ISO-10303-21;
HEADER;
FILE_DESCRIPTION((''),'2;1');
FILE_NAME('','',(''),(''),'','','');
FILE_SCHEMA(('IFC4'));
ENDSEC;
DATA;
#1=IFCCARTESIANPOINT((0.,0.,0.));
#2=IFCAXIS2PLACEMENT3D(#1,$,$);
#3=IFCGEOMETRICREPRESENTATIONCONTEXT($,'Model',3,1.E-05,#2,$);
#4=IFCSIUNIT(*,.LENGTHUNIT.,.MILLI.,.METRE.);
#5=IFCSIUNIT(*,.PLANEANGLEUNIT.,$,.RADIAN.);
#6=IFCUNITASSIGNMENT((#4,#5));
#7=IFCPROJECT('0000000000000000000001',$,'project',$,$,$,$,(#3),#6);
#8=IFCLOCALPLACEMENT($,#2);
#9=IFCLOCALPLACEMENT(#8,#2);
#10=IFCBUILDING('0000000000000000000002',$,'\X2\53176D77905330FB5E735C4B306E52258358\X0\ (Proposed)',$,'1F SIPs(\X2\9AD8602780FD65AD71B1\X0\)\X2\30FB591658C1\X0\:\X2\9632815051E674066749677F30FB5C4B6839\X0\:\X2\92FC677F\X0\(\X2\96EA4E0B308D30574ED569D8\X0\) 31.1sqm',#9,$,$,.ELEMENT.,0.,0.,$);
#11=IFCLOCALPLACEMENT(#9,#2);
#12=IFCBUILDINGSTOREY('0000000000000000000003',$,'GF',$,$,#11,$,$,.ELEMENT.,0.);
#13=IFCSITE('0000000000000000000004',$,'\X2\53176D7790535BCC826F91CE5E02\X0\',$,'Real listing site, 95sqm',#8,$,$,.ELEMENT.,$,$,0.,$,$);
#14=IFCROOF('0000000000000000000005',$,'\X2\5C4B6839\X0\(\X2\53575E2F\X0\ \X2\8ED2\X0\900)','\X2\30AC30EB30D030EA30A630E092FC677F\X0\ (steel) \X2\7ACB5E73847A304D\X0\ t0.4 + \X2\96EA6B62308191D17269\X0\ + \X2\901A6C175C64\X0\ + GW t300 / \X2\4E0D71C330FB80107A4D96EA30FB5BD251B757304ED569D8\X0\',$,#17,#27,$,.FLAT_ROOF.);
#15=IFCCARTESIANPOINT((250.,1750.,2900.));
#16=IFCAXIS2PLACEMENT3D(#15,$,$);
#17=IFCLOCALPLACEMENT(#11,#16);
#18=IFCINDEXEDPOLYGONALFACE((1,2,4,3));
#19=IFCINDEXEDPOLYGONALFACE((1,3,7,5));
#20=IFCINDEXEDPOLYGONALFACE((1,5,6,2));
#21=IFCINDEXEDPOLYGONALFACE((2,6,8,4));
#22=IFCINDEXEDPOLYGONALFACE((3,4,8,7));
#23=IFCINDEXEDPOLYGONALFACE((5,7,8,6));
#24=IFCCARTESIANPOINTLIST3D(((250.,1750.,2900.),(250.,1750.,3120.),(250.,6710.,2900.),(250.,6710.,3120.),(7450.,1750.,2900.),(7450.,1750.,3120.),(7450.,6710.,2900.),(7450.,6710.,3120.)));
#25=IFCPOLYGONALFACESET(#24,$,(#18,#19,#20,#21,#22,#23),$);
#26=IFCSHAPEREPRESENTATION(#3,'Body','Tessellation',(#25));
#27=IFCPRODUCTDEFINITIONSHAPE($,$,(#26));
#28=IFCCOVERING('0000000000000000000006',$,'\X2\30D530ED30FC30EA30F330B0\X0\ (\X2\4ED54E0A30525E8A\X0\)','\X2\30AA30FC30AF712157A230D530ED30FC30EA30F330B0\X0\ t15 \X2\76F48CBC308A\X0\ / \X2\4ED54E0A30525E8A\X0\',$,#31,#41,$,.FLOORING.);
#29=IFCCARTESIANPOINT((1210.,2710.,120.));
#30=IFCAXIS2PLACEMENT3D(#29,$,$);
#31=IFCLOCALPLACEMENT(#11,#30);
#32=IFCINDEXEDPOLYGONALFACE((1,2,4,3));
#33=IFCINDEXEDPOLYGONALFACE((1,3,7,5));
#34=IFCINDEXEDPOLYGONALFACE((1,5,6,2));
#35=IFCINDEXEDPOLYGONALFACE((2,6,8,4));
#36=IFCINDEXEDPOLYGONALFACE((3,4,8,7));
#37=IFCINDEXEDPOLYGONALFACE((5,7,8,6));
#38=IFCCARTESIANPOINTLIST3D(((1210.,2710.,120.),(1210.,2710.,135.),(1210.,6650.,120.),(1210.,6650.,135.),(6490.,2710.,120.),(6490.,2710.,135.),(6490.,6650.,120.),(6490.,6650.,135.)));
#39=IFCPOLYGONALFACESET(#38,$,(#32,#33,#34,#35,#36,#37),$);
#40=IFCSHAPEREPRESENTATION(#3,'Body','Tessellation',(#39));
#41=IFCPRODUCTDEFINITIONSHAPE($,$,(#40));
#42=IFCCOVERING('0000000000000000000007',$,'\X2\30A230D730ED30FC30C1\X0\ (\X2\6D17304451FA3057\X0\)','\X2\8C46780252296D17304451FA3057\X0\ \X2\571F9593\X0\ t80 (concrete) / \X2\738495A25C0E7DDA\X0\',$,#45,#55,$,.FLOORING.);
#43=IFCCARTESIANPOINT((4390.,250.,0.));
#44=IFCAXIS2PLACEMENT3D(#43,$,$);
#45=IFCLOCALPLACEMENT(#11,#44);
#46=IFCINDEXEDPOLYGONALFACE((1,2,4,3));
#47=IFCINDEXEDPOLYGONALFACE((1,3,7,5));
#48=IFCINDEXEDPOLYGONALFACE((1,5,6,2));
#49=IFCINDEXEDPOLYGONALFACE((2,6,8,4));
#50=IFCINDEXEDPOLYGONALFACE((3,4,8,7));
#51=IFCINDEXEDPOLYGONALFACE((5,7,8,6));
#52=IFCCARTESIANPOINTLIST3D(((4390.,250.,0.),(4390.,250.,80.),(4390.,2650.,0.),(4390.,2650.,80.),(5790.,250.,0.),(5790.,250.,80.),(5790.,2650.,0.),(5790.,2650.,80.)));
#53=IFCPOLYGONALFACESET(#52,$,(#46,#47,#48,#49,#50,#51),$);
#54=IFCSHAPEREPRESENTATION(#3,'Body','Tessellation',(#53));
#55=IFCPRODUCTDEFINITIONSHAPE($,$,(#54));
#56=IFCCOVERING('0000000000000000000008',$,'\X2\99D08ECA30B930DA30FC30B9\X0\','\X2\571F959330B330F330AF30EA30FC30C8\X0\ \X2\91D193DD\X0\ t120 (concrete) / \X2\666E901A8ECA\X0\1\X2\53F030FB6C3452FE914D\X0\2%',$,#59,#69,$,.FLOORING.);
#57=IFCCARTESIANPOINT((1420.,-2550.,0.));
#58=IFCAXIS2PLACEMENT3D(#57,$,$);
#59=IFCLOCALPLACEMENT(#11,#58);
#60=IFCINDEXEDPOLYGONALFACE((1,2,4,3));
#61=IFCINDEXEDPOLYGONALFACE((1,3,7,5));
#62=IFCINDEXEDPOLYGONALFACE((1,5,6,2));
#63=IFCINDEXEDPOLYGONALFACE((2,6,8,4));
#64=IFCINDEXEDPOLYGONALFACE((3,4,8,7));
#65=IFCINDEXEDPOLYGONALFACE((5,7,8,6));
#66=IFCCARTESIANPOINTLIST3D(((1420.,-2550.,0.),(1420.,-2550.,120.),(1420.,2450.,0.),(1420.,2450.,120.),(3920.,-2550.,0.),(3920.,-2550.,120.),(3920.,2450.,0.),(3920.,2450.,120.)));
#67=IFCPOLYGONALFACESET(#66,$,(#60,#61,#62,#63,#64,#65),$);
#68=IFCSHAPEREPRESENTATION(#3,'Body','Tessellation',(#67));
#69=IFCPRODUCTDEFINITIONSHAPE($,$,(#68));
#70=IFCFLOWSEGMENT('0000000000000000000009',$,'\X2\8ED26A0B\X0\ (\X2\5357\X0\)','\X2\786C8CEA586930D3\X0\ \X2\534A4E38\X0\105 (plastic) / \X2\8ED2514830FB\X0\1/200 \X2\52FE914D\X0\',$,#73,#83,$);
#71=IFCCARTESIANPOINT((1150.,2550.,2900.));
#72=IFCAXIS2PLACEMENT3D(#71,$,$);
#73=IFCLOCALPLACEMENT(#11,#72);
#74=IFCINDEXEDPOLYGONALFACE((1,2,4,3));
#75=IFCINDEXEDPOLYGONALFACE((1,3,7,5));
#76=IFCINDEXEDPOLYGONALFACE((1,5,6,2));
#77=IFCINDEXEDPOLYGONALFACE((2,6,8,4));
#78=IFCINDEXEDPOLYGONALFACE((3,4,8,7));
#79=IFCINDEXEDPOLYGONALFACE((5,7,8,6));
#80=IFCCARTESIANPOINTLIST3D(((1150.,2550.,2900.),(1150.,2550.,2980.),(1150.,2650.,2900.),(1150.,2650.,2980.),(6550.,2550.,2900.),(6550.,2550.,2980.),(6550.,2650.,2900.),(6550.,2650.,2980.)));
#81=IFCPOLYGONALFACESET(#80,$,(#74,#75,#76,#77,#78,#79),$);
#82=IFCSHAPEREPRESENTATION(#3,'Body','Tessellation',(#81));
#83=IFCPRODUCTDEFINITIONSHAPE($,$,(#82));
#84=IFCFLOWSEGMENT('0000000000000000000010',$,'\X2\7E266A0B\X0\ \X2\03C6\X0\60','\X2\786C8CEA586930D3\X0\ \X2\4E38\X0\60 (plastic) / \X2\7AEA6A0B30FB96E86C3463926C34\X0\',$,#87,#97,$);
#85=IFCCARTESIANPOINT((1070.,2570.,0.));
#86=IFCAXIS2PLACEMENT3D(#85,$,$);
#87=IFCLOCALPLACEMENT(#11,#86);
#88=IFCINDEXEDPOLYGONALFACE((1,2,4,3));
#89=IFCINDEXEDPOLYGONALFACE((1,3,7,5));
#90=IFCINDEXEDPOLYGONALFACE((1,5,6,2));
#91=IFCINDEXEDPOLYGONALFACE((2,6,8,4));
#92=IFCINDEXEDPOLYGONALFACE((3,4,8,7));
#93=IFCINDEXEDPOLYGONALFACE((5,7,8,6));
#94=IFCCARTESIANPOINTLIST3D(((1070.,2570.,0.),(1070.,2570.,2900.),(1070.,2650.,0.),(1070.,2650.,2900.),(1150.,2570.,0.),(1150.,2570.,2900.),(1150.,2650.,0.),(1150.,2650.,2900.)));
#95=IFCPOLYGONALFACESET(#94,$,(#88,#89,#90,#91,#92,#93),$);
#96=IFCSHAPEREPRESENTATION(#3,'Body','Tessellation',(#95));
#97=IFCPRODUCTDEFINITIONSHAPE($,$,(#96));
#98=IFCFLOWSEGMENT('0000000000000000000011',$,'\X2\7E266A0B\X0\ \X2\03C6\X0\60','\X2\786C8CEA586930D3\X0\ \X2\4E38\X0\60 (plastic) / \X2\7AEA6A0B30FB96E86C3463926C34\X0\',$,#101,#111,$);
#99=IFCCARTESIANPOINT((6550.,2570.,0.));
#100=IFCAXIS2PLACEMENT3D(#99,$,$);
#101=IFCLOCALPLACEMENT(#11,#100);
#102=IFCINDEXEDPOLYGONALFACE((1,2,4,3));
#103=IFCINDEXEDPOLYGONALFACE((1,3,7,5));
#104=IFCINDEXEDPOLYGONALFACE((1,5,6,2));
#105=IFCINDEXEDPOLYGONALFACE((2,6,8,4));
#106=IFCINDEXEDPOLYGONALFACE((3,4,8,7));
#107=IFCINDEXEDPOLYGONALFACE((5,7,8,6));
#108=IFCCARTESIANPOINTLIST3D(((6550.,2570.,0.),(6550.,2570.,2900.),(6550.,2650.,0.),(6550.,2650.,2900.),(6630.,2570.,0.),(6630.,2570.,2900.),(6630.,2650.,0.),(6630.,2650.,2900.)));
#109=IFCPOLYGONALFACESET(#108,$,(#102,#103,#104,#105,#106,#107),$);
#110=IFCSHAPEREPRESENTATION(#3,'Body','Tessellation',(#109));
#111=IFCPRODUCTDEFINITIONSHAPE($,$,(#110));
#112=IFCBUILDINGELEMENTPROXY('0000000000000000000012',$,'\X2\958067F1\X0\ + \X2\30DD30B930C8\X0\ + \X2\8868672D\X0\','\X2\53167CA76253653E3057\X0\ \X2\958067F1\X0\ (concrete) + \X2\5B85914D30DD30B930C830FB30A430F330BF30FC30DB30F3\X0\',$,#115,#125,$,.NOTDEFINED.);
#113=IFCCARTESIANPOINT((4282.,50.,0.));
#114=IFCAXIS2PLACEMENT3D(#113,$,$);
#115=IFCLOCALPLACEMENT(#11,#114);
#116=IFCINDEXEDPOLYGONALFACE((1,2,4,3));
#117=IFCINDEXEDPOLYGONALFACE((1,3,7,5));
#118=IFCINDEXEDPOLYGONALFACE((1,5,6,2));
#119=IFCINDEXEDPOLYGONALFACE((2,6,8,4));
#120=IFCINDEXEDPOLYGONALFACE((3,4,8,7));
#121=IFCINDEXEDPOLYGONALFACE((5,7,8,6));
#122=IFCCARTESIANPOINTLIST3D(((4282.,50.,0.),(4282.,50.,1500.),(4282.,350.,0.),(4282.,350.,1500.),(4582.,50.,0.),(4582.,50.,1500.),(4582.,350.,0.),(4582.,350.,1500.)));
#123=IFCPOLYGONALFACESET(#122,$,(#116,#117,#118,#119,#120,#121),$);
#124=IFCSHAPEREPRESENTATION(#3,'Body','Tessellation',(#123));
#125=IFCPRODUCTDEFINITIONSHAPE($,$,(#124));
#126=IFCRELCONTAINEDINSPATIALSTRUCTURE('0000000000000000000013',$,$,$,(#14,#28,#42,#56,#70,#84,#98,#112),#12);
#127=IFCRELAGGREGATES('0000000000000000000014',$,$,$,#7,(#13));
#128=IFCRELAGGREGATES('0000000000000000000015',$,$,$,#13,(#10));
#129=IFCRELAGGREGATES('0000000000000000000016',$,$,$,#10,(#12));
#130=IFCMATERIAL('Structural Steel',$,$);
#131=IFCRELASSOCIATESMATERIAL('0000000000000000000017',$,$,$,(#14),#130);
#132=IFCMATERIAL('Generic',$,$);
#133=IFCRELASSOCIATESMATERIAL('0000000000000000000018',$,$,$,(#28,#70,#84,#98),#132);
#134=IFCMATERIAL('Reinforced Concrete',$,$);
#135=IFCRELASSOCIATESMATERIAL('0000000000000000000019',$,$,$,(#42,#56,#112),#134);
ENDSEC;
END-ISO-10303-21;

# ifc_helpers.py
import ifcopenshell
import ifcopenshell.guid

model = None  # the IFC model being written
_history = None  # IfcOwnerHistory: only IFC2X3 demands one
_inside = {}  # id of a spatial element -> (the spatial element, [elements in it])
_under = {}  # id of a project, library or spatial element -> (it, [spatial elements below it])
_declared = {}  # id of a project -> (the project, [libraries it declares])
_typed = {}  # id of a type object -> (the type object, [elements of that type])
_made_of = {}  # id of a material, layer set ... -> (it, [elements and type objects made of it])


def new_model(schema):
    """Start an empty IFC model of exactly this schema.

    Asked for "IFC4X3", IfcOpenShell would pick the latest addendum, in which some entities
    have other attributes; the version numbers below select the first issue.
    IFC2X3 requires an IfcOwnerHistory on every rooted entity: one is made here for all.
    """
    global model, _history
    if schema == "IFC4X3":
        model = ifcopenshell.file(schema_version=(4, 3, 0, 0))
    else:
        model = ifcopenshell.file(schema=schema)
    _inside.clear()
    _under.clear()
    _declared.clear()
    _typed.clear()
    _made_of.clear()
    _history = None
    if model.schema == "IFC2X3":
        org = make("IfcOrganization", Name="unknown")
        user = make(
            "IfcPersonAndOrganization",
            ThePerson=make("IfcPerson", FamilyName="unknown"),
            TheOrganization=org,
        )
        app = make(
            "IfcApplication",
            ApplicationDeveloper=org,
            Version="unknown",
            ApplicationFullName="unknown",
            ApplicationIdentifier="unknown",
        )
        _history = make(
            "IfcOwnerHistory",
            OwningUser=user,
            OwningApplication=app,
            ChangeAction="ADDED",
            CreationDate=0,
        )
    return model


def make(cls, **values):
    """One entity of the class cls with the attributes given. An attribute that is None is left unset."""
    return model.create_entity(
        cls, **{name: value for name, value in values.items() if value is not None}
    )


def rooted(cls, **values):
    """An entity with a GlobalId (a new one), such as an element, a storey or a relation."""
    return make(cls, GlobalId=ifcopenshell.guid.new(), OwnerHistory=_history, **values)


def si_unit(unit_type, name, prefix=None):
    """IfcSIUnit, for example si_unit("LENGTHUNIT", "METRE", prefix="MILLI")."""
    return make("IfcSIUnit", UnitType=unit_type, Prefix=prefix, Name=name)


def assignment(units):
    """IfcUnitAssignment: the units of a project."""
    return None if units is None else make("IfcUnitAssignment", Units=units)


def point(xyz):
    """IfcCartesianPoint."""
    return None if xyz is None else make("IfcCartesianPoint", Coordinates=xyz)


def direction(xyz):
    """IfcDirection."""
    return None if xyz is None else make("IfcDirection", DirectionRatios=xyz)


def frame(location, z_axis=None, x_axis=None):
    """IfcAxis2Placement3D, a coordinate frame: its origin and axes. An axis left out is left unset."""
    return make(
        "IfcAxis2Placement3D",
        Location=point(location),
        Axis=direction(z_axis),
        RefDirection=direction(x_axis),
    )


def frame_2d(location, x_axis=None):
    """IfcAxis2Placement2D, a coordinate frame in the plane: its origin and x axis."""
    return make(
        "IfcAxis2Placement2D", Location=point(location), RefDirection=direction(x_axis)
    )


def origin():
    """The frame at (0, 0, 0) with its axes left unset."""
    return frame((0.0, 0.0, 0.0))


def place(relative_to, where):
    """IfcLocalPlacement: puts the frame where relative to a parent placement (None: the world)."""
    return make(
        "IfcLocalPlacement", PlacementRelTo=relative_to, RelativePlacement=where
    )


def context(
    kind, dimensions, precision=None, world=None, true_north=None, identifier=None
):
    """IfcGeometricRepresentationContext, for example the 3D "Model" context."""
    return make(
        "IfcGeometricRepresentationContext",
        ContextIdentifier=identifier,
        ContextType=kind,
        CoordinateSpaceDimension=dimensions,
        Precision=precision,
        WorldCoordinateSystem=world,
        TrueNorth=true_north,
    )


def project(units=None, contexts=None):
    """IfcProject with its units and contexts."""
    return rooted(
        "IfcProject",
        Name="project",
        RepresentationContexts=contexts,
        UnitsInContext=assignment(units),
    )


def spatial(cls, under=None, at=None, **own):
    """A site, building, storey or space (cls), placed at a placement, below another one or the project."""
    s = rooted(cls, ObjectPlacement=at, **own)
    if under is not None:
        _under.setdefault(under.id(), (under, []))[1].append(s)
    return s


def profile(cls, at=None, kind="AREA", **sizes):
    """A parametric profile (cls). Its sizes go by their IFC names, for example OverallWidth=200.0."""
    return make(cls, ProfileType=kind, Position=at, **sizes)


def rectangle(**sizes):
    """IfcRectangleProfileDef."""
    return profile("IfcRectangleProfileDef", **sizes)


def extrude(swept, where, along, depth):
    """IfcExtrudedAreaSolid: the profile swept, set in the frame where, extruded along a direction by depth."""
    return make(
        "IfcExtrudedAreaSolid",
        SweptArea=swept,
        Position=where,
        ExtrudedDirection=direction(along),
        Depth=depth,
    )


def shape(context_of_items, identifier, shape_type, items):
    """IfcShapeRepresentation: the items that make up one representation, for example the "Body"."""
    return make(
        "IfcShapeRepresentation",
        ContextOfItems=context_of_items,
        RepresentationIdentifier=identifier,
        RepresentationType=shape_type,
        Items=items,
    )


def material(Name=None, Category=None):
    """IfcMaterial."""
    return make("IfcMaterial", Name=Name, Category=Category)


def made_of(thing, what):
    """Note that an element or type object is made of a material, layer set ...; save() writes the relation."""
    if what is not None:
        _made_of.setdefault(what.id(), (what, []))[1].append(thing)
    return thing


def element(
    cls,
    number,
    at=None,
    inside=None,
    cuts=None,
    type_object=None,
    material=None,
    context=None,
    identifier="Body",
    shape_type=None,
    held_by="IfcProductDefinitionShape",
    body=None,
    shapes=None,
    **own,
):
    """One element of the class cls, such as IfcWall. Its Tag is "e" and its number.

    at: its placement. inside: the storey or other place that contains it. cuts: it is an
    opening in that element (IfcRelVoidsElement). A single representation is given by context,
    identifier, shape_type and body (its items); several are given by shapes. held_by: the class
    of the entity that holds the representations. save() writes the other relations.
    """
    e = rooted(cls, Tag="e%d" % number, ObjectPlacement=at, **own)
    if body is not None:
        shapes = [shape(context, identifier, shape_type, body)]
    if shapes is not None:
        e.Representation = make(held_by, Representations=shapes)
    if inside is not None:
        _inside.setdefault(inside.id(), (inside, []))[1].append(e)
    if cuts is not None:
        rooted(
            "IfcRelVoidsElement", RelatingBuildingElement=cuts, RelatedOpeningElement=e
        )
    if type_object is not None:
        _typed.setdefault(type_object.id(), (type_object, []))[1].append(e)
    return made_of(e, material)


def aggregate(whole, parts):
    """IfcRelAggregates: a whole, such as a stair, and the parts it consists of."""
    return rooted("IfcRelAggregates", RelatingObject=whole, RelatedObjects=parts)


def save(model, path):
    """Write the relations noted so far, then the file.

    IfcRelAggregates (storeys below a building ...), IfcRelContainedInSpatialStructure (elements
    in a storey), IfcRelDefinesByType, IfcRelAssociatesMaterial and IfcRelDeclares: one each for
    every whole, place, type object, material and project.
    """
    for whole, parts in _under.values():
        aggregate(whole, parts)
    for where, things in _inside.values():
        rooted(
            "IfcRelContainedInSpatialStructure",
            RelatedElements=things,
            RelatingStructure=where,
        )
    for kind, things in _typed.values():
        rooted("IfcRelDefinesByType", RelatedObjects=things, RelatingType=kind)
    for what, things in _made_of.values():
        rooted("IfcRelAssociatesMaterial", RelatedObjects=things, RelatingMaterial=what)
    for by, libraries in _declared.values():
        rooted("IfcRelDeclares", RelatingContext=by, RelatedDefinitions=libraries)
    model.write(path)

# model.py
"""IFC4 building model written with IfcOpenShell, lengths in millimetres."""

from ifc_helpers import new_model, si_unit, frame, frame_2d, origin, place, context, project, spatial, rectangle, extrude, material, element, save


model = new_model("IFC4")

# Units and contexts
model_context = context("Model", 3, precision=1e-05, world=origin())
ifc_project = project(units=[si_unit("LENGTHUNIT", "METRE", prefix="MILLI"), si_unit("PLANEANGLEUNIT", "RADIAN")], contexts=[model_context])

# Site, building, storey
site_placement = place(None, origin())
site = spatial("IfcSite", under=ifc_project, at=site_placement, Name="北海道富良野市", ObjectType="Real listing site, 95sqm", CompositionType="ELEMENT", RefElevation=0.0)
building_placement = place(site_placement, origin())
building = spatial("IfcBuilding", under=site, at=building_placement, Name="北海道・平屋の別荘 (Proposed)", ObjectType="1F SIPs(高性能断熱)・外壁:防腐処理杉板・屋根:鋼板(雪下ろし仕様) 31.1sqm", CompositionType="ELEMENT", ElevationOfRefHeight=0.0, ElevationOfTerrain=0.0)
storey_placement = place(building_placement, origin())
storey = spatial("IfcBuildingStorey", under=building, at=storey_placement, Name="GF", CompositionType="ELEMENT", Elevation=0.0)

# Shared definitions
ifc_material_1 = material(Name="Reinforced Concrete")

# Roof
ifc_material_2 = material(Name="Structural Steel")
roof_placement = place(storey_placement, frame((250.0, 1750.0, 2900.0)))
element("IfcRoof", 1, at=roof_placement, inside=storey, material=ifc_material_2, Name="屋根(南帯 軒900)", Description="ガルバリウム鋼板 (steel) 立平葺き t0.4 + 雪止め金物 + 通気層 + GW t300 / 不燃・耐積雪・寒冷地仕様", PredefinedType="FLAT_ROOF", context=model_context, shape_type="SweptSolid", body=[
    extrude(rectangle(XDim=7200.0, YDim=4960.0, at=frame_2d((3600.0, 2480.0))), frame((250.0, 1750.0, 2900.0)), (0.0, 0.0, 1.0), 220.0),
])

# Coverings
ifc_material_3 = material(Name="Generic")
covering_1_placement = place(storey_placement, frame((1210.0, 2710.0, 120.0)))
element("IfcCovering", 2, at=covering_1_placement, inside=storey, material=ifc_material_3, Name="フローリング (仕上げ床)", Description="オーク無垢フローリング t15 直貼り / 仕上げ床", PredefinedType="FLOORING", context=model_context, shape_type="SweptSolid", body=[
    extrude(rectangle(XDim=5280.0, YDim=3940.0, at=frame_2d((2640.0, 1970.0))), frame((1210.0, 2710.0, 120.0)), (0.0, 0.0, 1.0), 15.0),
])
covering_2_placement = place(storey_placement, frame((4390.0, 250.0, 0.0)))
element("IfcCovering", 3, at=covering_2_placement, inside=storey, material=ifc_material_1, Name="アプローチ (洗い出し)", Description="豆砂利洗い出し 土間 t80 (concrete) / 玄関導線", PredefinedType="FLOORING", context=model_context, shape_type="SweptSolid", body=[
    extrude(rectangle(XDim=1400.0, YDim=2400.0, at=frame_2d((700.0, 1200.0))), frame((4390.0, 250.0, 0.0)), (0.0, 0.0, 1.0), 80.0),
])
covering_3_placement = place(storey_placement, frame((1420.0, -2550.0, 0.0)))
element("IfcCovering", 4, at=covering_3_placement, inside=storey, material=ifc_material_1, Name="駐車スペース", Description="土間コンクリート 金鏝 t120 (concrete) / 普通車1台・水勾配2%", PredefinedType="FLOORING", context=model_context, shape_type="SweptSolid", body=[
    extrude(rectangle(XDim=2500.0, YDim=5000.0, at=frame_2d((1250.0, 2500.0))), frame((1420.0, -2550.0, 0.0)), (0.0, 0.0, 1.0), 120.0),
])

# Flow segments
flow_segment_1_placement = place(storey_placement, frame((1150.0, 2550.0, 2900.0)))
element("IfcFlowSegment", 5, at=flow_segment_1_placement, inside=storey, material=ifc_material_3, Name="軒樋 (南)", Description="硬質塩ビ 半丸105 (plastic) / 軒先・1/200 勾配", context=model_context, shape_type="SweptSolid", body=[
    extrude(rectangle(XDim=5400.0, YDim=100.0, at=frame_2d((2700.0, 50.0))), frame((1150.0, 2550.0, 2900.0)), (0.0, 0.0, 1.0), 80.0),
])
flow_segment_2_placement = place(storey_placement, frame((1070.0, 2570.0, 0.0)))
element("IfcFlowSegment", 6, at=flow_segment_2_placement, inside=storey, material=ifc_material_3, Name="縦樋 φ60", Description="硬質塩ビ 丸60 (plastic) / 竪樋・雨水排水", context=model_context, shape_type="SweptSolid", body=[
    extrude(rectangle(XDim=80.0, YDim=80.0, at=frame_2d((40.0, 40.0))), frame((1070.0, 2570.0, 0.0)), (0.0, 0.0, 1.0), 2900.0),
])
flow_segment_3_placement = place(storey_placement, frame((6550.0, 2570.0, 0.0)))
element("IfcFlowSegment", 7, at=flow_segment_3_placement, inside=storey, material=ifc_material_3, Name="縦樋 φ60", Description="硬質塩ビ 丸60 (plastic) / 竪樋・雨水排水", context=model_context, shape_type="SweptSolid", body=[
    extrude(rectangle(XDim=80.0, YDim=80.0, at=frame_2d((40.0, 40.0))), frame((6550.0, 2570.0, 0.0)), (0.0, 0.0, 1.0), 2900.0),
])

# Building element proxy
proxy_placement = place(storey_placement, frame((4282.0, 50.0, 0.0)))
element("IfcBuildingElementProxy", 8, at=proxy_placement, inside=storey, material=ifc_material_1, Name="門柱 + ポスト + 表札", Description="化粧打放し 門柱 (concrete) + 宅配ポスト・インターホン", PredefinedType="NOTDEFINED", context=model_context, shape_type="SweptSolid", body=[
    extrude(rectangle(XDim=300.0, YDim=300.0, at=frame_2d((150.0, 150.0))), frame((4282.0, 50.0, 0.0)), (0.0, 0.0, 1.0), 1500.0),
])

save(model, "model.ifc")
